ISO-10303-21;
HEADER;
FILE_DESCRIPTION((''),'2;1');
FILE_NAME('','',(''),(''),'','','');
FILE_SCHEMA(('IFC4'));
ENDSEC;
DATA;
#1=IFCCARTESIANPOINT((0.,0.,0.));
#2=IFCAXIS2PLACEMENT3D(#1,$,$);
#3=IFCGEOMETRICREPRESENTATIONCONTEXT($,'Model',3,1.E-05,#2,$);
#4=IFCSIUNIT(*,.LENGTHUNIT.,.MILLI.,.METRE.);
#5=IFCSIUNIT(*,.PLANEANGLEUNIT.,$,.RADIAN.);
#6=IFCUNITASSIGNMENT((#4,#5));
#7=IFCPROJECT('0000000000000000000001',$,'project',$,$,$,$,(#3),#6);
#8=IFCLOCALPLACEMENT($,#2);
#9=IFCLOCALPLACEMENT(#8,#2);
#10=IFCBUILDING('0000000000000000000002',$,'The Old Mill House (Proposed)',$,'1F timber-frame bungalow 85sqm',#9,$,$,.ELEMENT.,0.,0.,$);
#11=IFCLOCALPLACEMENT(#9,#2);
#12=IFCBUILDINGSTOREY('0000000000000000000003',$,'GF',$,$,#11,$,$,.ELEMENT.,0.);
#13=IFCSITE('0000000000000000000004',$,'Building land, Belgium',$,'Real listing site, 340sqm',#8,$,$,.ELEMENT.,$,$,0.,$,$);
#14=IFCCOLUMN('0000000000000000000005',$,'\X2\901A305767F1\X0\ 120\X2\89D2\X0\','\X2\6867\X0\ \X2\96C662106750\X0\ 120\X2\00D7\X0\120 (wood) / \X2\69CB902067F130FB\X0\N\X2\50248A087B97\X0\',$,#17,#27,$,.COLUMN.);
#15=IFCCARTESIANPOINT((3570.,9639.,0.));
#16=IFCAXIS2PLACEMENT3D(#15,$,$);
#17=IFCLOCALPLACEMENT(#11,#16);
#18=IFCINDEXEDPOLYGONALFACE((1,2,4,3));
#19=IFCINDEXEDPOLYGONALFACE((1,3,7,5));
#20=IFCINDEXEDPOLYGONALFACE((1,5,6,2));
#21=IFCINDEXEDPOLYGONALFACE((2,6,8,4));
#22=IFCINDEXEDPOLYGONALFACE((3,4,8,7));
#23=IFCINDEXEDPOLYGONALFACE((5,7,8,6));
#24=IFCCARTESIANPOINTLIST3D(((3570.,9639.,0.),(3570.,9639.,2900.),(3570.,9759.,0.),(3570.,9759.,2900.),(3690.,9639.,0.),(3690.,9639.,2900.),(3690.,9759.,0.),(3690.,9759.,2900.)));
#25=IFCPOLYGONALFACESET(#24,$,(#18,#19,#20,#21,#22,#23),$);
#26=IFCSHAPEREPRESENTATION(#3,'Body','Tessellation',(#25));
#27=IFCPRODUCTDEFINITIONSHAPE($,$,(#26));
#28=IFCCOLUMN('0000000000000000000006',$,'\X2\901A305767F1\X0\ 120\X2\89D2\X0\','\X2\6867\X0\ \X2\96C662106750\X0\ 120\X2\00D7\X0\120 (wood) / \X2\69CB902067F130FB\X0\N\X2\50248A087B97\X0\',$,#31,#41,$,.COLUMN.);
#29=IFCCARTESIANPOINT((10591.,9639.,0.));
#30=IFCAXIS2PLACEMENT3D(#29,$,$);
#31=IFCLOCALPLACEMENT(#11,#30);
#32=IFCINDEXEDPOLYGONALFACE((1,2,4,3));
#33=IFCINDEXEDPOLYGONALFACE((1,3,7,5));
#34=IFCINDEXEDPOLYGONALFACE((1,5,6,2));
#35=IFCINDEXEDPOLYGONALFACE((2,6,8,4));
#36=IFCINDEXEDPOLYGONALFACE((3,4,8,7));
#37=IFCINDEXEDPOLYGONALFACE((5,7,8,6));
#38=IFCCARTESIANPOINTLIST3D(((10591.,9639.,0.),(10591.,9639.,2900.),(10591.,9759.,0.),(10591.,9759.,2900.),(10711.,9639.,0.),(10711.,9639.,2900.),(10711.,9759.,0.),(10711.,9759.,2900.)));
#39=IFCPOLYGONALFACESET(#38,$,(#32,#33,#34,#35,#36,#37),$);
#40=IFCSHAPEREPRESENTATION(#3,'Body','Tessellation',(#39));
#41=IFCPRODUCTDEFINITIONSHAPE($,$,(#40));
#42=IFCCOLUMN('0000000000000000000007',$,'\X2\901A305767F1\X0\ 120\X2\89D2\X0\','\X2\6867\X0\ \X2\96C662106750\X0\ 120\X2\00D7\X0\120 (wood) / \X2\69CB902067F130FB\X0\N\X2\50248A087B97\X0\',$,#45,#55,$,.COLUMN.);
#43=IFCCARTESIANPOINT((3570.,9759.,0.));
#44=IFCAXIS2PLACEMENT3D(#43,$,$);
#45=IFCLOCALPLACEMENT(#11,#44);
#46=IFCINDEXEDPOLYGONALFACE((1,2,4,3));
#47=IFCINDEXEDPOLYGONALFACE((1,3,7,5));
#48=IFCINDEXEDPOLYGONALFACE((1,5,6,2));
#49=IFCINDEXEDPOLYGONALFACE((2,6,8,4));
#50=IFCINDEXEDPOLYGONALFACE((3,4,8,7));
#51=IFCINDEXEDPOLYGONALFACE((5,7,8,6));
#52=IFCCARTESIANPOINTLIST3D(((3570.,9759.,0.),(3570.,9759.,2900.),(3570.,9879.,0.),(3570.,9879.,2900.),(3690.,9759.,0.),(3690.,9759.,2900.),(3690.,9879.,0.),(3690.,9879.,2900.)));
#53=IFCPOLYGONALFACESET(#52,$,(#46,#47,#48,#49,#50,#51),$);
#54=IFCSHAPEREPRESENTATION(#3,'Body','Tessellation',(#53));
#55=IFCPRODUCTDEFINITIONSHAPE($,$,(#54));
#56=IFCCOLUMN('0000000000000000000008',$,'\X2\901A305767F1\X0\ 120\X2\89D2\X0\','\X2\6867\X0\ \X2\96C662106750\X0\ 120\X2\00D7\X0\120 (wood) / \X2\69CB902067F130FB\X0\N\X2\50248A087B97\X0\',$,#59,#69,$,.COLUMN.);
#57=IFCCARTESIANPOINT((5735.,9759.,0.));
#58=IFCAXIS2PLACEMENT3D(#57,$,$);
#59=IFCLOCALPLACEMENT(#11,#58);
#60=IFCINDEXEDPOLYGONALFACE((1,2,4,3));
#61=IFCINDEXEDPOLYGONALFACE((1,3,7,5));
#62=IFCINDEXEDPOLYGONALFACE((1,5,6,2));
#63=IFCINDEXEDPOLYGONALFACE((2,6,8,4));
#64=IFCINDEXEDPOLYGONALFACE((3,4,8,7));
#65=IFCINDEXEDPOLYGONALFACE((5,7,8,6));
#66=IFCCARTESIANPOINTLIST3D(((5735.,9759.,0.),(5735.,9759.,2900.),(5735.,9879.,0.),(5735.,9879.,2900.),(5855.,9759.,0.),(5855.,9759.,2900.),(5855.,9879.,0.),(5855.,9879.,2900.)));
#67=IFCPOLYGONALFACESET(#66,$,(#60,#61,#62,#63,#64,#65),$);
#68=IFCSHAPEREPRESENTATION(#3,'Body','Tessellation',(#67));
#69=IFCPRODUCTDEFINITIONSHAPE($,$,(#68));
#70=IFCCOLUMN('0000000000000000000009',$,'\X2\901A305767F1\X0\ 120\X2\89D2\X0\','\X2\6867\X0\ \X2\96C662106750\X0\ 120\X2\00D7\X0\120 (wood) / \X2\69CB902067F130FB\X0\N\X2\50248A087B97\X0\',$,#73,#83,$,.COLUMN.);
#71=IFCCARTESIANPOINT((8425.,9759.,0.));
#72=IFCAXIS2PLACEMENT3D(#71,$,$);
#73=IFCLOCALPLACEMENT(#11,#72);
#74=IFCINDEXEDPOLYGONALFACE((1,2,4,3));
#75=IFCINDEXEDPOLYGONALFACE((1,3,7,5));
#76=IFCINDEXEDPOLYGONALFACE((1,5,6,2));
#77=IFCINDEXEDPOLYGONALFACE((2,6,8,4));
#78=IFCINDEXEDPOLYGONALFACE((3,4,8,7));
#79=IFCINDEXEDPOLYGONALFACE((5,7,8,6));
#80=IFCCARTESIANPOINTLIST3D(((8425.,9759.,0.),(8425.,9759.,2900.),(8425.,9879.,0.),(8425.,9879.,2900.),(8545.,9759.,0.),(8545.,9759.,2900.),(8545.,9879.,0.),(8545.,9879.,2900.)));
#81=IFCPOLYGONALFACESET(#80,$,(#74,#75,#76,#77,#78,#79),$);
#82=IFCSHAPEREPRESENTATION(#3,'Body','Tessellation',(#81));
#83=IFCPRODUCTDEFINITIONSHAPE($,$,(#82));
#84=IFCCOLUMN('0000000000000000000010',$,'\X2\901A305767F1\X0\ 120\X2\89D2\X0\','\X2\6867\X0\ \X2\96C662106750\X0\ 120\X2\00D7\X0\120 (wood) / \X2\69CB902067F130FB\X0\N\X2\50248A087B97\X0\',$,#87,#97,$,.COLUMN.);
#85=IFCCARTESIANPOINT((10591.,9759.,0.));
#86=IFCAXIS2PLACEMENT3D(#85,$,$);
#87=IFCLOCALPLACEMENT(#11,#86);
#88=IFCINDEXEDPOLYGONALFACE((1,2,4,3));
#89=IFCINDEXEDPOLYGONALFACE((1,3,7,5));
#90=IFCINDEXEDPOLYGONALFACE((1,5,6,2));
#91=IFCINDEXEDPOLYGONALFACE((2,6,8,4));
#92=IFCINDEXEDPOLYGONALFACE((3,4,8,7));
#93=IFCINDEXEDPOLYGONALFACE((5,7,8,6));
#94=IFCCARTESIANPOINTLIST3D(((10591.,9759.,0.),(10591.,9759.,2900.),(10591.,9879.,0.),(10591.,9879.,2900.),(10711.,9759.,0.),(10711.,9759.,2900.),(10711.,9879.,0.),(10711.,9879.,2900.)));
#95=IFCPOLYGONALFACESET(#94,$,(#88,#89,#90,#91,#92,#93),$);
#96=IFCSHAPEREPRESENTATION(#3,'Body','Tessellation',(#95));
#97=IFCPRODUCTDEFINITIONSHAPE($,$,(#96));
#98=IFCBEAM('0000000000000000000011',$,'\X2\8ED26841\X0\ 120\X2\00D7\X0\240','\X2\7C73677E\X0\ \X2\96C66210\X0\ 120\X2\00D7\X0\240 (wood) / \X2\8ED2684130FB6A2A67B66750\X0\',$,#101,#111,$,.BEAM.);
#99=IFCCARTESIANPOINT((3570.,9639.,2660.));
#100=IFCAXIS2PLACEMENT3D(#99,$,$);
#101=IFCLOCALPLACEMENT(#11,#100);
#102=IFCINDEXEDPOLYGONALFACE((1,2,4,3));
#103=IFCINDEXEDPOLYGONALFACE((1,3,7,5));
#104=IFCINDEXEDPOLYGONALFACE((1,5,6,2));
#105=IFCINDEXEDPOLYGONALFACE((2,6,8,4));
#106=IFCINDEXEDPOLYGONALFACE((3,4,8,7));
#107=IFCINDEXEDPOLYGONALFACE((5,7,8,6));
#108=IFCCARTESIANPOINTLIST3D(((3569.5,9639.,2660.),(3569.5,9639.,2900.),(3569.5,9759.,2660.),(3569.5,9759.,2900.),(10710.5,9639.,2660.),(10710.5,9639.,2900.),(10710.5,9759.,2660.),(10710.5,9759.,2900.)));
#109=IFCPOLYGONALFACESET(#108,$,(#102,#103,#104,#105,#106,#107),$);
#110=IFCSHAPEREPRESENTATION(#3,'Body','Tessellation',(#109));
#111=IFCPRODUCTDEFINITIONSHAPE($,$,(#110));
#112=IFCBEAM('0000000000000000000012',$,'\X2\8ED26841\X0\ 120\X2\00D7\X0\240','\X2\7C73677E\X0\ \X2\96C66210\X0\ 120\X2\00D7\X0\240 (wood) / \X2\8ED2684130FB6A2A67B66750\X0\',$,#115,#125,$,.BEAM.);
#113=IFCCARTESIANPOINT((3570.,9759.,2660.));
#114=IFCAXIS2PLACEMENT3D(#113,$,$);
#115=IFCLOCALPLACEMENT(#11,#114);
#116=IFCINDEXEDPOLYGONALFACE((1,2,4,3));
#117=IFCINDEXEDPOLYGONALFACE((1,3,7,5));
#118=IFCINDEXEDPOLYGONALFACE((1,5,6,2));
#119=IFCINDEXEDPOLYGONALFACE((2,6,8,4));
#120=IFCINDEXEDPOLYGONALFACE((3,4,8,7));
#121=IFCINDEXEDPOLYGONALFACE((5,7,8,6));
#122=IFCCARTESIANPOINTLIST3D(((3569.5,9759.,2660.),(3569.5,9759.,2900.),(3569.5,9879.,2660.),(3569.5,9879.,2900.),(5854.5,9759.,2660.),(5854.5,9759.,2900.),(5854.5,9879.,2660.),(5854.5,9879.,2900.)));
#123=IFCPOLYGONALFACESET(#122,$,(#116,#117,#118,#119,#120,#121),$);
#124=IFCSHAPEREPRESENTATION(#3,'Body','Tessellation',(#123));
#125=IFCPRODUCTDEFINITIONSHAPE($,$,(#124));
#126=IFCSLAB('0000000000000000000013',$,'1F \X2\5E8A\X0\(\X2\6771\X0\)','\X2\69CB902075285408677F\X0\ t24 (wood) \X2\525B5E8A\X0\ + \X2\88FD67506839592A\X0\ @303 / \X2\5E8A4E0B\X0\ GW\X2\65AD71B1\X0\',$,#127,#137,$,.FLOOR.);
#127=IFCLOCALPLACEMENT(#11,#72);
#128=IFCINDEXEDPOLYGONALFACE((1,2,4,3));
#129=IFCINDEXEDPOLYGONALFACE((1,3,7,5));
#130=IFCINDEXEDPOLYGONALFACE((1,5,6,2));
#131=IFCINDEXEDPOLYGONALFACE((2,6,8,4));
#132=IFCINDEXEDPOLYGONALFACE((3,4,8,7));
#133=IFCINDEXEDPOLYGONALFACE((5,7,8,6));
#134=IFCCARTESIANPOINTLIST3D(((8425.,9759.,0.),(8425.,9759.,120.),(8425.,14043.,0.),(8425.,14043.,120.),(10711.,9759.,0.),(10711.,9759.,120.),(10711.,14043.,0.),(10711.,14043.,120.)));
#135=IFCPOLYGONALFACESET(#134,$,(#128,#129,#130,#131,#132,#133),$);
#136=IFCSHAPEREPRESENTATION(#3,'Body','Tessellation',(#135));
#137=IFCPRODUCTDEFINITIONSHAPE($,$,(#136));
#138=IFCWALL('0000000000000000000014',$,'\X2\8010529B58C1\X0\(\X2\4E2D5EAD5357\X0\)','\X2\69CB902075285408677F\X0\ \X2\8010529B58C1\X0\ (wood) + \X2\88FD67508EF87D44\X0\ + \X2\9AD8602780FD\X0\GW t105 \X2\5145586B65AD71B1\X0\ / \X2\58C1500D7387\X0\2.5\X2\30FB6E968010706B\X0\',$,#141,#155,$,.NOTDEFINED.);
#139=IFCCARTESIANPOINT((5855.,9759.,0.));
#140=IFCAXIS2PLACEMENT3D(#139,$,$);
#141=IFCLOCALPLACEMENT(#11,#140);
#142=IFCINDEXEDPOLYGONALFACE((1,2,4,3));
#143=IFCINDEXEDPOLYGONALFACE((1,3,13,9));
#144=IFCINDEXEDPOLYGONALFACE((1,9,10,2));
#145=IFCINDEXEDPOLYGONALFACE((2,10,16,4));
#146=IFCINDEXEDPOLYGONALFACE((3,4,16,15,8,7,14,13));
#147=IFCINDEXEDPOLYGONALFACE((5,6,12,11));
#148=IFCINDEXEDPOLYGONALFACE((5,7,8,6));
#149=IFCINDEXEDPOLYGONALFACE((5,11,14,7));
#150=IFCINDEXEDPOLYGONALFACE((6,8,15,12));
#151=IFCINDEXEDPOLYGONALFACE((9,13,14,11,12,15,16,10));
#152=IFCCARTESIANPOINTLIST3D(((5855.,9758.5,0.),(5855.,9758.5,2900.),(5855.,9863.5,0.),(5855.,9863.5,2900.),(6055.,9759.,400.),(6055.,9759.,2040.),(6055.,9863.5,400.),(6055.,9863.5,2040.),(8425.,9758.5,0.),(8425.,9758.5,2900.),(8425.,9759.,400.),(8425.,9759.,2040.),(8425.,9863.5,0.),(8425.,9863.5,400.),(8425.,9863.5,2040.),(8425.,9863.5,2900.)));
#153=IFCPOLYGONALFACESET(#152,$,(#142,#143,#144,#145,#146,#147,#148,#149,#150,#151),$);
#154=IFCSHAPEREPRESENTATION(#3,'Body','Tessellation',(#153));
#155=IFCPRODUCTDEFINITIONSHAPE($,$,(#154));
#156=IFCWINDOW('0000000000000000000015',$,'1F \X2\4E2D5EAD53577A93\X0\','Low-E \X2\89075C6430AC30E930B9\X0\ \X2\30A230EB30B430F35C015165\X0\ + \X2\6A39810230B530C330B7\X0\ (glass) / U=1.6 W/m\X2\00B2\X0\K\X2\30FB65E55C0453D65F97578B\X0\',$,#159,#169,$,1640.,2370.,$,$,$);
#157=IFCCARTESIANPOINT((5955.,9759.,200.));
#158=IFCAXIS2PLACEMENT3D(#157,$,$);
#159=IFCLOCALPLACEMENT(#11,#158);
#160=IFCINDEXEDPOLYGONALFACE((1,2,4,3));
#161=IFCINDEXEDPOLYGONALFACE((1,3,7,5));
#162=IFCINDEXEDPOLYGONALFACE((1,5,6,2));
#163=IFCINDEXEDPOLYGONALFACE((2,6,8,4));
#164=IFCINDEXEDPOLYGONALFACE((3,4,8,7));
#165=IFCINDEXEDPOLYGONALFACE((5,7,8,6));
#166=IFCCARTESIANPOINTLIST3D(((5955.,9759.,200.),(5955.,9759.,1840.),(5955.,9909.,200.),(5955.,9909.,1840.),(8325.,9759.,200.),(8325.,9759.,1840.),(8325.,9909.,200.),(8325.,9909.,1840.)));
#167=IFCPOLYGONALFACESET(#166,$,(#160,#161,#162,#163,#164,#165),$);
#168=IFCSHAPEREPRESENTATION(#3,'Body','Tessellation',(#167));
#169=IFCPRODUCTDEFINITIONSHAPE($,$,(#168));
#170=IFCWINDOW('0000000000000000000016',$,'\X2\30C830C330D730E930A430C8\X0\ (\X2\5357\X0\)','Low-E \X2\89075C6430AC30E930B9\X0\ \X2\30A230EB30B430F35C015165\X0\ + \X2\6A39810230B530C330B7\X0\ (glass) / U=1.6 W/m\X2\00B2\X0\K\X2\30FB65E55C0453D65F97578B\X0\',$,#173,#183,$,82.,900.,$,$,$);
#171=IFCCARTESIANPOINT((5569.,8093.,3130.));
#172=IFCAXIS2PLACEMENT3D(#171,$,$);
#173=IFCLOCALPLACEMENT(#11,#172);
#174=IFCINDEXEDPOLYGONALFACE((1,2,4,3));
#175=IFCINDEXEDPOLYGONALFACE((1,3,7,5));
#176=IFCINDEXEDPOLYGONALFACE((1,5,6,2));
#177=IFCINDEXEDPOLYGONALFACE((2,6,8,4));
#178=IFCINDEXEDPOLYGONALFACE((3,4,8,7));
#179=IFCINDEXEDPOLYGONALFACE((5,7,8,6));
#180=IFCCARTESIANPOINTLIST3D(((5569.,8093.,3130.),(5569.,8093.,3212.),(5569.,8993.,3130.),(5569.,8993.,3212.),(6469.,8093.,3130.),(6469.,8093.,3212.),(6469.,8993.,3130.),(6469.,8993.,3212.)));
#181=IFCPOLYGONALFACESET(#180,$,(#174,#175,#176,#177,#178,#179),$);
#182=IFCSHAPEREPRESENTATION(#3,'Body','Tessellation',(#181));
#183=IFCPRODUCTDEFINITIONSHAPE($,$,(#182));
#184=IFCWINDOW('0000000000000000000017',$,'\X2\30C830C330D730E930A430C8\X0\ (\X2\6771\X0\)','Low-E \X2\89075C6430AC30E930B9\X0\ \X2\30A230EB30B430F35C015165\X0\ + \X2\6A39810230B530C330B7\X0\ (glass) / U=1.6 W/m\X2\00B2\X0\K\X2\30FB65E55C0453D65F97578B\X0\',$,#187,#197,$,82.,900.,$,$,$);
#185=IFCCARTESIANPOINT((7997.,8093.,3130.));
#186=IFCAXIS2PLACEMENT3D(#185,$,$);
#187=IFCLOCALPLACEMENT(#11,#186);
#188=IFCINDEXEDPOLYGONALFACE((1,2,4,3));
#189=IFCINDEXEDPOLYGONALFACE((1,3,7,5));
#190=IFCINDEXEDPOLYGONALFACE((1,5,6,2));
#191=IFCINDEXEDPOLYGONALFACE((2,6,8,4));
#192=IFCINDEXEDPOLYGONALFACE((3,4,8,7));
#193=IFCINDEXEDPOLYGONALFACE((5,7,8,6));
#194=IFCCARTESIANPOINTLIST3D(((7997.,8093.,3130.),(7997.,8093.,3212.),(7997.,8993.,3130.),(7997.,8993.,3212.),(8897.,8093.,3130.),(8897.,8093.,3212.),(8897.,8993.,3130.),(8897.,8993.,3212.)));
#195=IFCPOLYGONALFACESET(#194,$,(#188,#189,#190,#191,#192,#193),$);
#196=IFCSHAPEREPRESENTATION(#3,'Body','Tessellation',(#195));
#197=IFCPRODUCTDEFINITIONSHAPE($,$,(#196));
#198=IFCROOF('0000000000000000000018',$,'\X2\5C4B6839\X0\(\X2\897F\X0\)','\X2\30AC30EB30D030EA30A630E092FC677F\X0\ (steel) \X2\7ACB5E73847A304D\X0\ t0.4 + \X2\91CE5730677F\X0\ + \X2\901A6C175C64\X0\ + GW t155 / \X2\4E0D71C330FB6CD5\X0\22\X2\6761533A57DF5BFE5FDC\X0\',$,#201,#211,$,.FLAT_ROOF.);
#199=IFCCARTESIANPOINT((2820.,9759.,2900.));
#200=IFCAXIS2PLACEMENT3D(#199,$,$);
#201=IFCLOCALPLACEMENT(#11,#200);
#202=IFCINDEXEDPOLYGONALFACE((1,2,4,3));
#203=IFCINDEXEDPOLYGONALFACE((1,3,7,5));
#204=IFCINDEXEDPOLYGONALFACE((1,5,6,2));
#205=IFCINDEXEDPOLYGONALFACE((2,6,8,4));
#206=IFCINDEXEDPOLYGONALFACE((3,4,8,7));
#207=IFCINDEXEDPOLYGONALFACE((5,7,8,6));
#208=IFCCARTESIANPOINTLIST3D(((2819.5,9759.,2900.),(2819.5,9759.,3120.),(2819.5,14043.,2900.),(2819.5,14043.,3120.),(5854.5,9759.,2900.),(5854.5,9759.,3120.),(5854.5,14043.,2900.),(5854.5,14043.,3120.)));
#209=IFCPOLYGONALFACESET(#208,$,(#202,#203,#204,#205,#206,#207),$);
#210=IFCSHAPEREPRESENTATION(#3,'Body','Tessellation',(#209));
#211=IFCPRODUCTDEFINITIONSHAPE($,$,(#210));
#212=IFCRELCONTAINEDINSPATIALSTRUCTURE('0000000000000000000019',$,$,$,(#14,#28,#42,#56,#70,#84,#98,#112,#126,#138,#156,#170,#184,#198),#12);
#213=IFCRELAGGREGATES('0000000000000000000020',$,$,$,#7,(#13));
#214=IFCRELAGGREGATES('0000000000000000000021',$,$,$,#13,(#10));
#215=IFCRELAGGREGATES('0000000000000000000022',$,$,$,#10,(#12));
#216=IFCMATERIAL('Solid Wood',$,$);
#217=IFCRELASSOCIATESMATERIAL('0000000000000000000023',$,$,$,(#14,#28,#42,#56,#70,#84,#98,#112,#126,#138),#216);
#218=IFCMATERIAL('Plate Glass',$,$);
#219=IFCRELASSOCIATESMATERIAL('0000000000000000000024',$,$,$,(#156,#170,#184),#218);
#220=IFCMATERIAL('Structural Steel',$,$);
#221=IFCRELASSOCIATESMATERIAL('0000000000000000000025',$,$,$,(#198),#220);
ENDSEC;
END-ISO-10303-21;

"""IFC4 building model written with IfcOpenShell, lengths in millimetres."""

from ifc_helpers import new_model, si_unit, frame, frame_2d, origin, place, context, project, spatial, rectangle, extrude, material, element, fill, save


model = new_model("IFC4")

# Units and contexts
model_context = context("Model", 3, precision=1e-05, world=origin())
ifc_project = project(units=[si_unit("LENGTHUNIT", "METRE", prefix="MILLI"), si_unit("PLANEANGLEUNIT", "RADIAN")], contexts=[model_context])

# Site, building, storey
site_placement = place(None, origin())
site = spatial("IfcSite", under=ifc_project, at=site_placement, Name="Building land, Belgium", ObjectType="Real listing site, 340sqm", CompositionType="ELEMENT", RefElevation=0.0)
building_placement = place(site_placement, origin())
building = spatial("IfcBuilding", under=site, at=building_placement, Name="The Old Mill House (Proposed)", ObjectType="1F timber-frame bungalow 85sqm", CompositionType="ELEMENT", ElevationOfRefHeight=0.0, ElevationOfTerrain=0.0)
storey_placement = place(building_placement, origin())
storey = spatial("IfcBuildingStorey", under=building, at=storey_placement, Name="GF", CompositionType="ELEMENT", Elevation=0.0)

# Columns
ifc_material_1 = material(Name="Solid Wood")
column_1_placement = place(storey_placement, frame((3570.0, 9639.0, 0.0)))
element("IfcColumn", 1, at=column_1_placement, inside=storey, material=ifc_material_1, Name="通し柱 120角", Description="桧 集成材 120×120 (wood) / 構造柱・N値計算", PredefinedType="COLUMN", context=model_context, shape_type="SweptSolid", body=[
    extrude(rectangle(XDim=120.0, YDim=120.0, at=frame_2d((60.0, 60.0))), frame((3570.0, 9639.0, 0.0)), (0.0, 0.0, 1.0), 2900.0),
])
column_2_placement = place(storey_placement, frame((10591.0, 9639.0, 0.0)))
element("IfcColumn", 2, at=column_2_placement, inside=storey, material=ifc_material_1, Name="通し柱 120角", Description="桧 集成材 120×120 (wood) / 構造柱・N値計算", PredefinedType="COLUMN", context=model_context, shape_type="SweptSolid", body=[
    extrude(rectangle(XDim=120.0, YDim=120.0, at=frame_2d((60.0, 60.0))), frame((10591.0, 9639.0, 0.0)), (0.0, 0.0, 1.0), 2900.0),
])
column_3_placement = place(storey_placement, frame((3570.0, 9759.0, 0.0)))
element("IfcColumn", 3, at=column_3_placement, inside=storey, material=ifc_material_1, Name="通し柱 120角", Description="桧 集成材 120×120 (wood) / 構造柱・N値計算", PredefinedType="COLUMN", context=model_context, shape_type="SweptSolid", body=[
    extrude(rectangle(XDim=120.0, YDim=120.0, at=frame_2d((60.0, 60.0))), frame((3570.0, 9759.0, 0.0)), (0.0, 0.0, 1.0), 2900.0),
])
column_4_placement = place(storey_placement, frame((5735.0, 9759.0, 0.0)))
element("IfcColumn", 4, at=column_4_placement, inside=storey, material=ifc_material_1, Name="通し柱 120角", Description="桧 集成材 120×120 (wood) / 構造柱・N値計算", PredefinedType="COLUMN", context=model_context, shape_type="SweptSolid", body=[
    extrude(rectangle(XDim=120.0, YDim=120.0, at=frame_2d((60.0, 60.0))), frame((5735.0, 9759.0, 0.0)), (0.0, 0.0, 1.0), 2900.0),
])
column_5_placement = place(storey_placement, frame((8425.0, 9759.0, 0.0)))
element("IfcColumn", 5, at=column_5_placement, inside=storey, material=ifc_material_1, Name="通し柱 120角", Description="桧 集成材 120×120 (wood) / 構造柱・N値計算", PredefinedType="COLUMN", context=model_context, shape_type="SweptSolid", body=[
    extrude(rectangle(XDim=120.0, YDim=120.0, at=frame_2d((60.0, 60.0))), frame((8425.0, 9759.0, 0.0)), (0.0, 0.0, 1.0), 2900.0),
])
column_6_placement = place(storey_placement, frame((10591.0, 9759.0, 0.0)))
element("IfcColumn", 6, at=column_6_placement, inside=storey, material=ifc_material_1, Name="通し柱 120角", Description="桧 集成材 120×120 (wood) / 構造柱・N値計算", PredefinedType="COLUMN", context=model_context, shape_type="SweptSolid", body=[
    extrude(rectangle(XDim=120.0, YDim=120.0, at=frame_2d((60.0, 60.0))), frame((10591.0, 9759.0, 0.0)), (0.0, 0.0, 1.0), 2900.0),
])

# Beams
beam_1_placement = place(storey_placement, frame((3570.0, 9639.0, 2660.0)))
element("IfcBeam", 7, at=beam_1_placement, inside=storey, material=ifc_material_1, Name="軒桁 120×240", Description="米松 集成 120×240 (wood) / 軒桁・横架材", PredefinedType="BEAM", context=model_context, shape_type="SweptSolid", body=[
    extrude(rectangle(XDim=7141.0, YDim=120.0, at=frame_2d((3570.0, 60.0))), frame((3570.0, 9639.0, 2660.0)), (0.0, 0.0, 1.0), 240.0),
])
beam_2_placement = place(storey_placement, frame((3570.0, 9759.0, 2660.0)))
element("IfcBeam", 8, at=beam_2_placement, inside=storey, material=ifc_material_1, Name="軒桁 120×240", Description="米松 集成 120×240 (wood) / 軒桁・横架材", PredefinedType="BEAM", context=model_context, shape_type="SweptSolid", body=[
    extrude(rectangle(XDim=2285.0, YDim=120.0, at=frame_2d((1142.0, 60.0))), frame((3570.0, 9759.0, 2660.0)), (0.0, 0.0, 1.0), 240.0),
])

# Slab
slab_1_placement = place(storey_placement, frame((8425.0, 9759.0, 0.0)))
element("IfcSlab", 9, at=slab_1_placement, inside=storey, material=ifc_material_1, Name="1F 床(東)", Description="構造用合板 t24 (wood) 剛床 + 製材根太 @303 / 床下 GW断熱", PredefinedType="FLOOR", context=model_context, shape_type="SweptSolid", body=[
    extrude(rectangle(XDim=2286.0, YDim=4284.0, at=frame_2d((1143.0, 2142.0))), frame((8425.0, 9759.0, 0.0)), (0.0, 0.0, 1.0), 120.0),
])

# Wall, opening, window
wall_1_placement = place(storey_placement, frame((5855.0, 9759.0, 0.0)))
wall_1 = element("IfcWall", 10, at=wall_1_placement, inside=storey, material=ifc_material_1, Name="耐力壁(中庭南)", Description="構造用合板 耐力壁 (wood) + 製材軸組 + 高性能GW t105 充填断熱 / 壁倍率2.5・準耐火", PredefinedType="NOTDEFINED", context=model_context, shape_type="SweptSolid", body=[
    extrude(rectangle(XDim=2570.0, YDim=105.0, at=frame_2d((1285.0, 52.0))), frame((5855.0, 9759.0, 0.0)), (0.0, 0.0, 1.0), 2900.0),
])
opening_placement = place(storey_placement, frame((5955.0, 9759.0, 200.0)))
opening = element("IfcOpeningElement", 11, at=opening_placement, cuts=wall_1, PredefinedType="NOTDEFINED", context=model_context, shape_type="SweptSolid", body=[
    extrude(rectangle(XDim=2370.0, YDim=150.0, at=frame_2d((1185.0, 75.0))), frame((5955.0, 9759.0, 200.0)), (0.0, 0.0, 1.0), 1640.0),
])
ifc_material_2 = material(Name="Plate Glass")
window_1_placement = place(storey_placement, frame((5955.0, 9759.0, 200.0)))
window_1 = element("IfcWindow", 12, at=window_1_placement, inside=storey, material=ifc_material_2, Name="1F 中庭南窓", Description="Low-E 複層ガラス アルゴン封入 + 樹脂サッシ (glass) / U=1.6 W/m²K・日射取得型", OverallHeight=1640.0, OverallWidth=2370.0, context=model_context, shape_type="SweptSolid", body=[
    extrude(rectangle(XDim=2370.0, YDim=150.0, at=frame_2d((1185.0, 75.0))), frame((5955.0, 9759.0, 200.0)), (0.0, 0.0, 1.0), 1640.0),
])
fill(opening, window_1)

# Windows
window_2_placement = place(storey_placement, frame((5569.0, 8093.0, 3130.0)))
element("IfcWindow", 13, at=window_2_placement, inside=storey, material=ifc_material_2, Name="トップライト (南)", Description="Low-E 複層ガラス アルゴン封入 + 樹脂サッシ (glass) / U=1.6 W/m²K・日射取得型", OverallHeight=82.0, OverallWidth=900.0, context=model_context, shape_type="SweptSolid", body=[
    extrude(rectangle(XDim=900.0, YDim=900.0, at=frame_2d((450.0, 450.0))), frame((5569.0, 8093.0, 3130.0)), (0.0, 0.0, 1.0), 82.0),
])
window_3_placement = place(storey_placement, frame((7997.0, 8093.0, 3130.0)))
element("IfcWindow", 14, at=window_3_placement, inside=storey, material=ifc_material_2, Name="トップライト (東)", Description="Low-E 複層ガラス アルゴン封入 + 樹脂サッシ (glass) / U=1.6 W/m²K・日射取得型", OverallHeight=82.0, OverallWidth=900.0, context=model_context, shape_type="SweptSolid", body=[
    extrude(rectangle(XDim=900.0, YDim=900.0, at=frame_2d((450.0, 450.0))), frame((7997.0, 8093.0, 3130.0)), (0.0, 0.0, 1.0), 82.0),
])

# Roof
ifc_material_3 = material(Name="Structural Steel")
roof_1_placement = place(storey_placement, frame((2820.0, 9759.0, 2900.0)))
element("IfcRoof", 15, at=roof_1_placement, inside=storey, material=ifc_material_3, Name="屋根(西)", Description="ガルバリウム鋼板 (steel) 立平葺き t0.4 + 野地板 + 通気層 + GW t155 / 不燃・法22条区域対応", PredefinedType="FLAT_ROOF", context=model_context, shape_type="SweptSolid", body=[
    extrude(rectangle(XDim=3035.0, YDim=4284.0, at=frame_2d((1517.0, 2142.0))), frame((2820.0, 9759.0, 2900.0)), (0.0, 0.0, 1.0), 220.0),
])

save(model, "model.ifc")
